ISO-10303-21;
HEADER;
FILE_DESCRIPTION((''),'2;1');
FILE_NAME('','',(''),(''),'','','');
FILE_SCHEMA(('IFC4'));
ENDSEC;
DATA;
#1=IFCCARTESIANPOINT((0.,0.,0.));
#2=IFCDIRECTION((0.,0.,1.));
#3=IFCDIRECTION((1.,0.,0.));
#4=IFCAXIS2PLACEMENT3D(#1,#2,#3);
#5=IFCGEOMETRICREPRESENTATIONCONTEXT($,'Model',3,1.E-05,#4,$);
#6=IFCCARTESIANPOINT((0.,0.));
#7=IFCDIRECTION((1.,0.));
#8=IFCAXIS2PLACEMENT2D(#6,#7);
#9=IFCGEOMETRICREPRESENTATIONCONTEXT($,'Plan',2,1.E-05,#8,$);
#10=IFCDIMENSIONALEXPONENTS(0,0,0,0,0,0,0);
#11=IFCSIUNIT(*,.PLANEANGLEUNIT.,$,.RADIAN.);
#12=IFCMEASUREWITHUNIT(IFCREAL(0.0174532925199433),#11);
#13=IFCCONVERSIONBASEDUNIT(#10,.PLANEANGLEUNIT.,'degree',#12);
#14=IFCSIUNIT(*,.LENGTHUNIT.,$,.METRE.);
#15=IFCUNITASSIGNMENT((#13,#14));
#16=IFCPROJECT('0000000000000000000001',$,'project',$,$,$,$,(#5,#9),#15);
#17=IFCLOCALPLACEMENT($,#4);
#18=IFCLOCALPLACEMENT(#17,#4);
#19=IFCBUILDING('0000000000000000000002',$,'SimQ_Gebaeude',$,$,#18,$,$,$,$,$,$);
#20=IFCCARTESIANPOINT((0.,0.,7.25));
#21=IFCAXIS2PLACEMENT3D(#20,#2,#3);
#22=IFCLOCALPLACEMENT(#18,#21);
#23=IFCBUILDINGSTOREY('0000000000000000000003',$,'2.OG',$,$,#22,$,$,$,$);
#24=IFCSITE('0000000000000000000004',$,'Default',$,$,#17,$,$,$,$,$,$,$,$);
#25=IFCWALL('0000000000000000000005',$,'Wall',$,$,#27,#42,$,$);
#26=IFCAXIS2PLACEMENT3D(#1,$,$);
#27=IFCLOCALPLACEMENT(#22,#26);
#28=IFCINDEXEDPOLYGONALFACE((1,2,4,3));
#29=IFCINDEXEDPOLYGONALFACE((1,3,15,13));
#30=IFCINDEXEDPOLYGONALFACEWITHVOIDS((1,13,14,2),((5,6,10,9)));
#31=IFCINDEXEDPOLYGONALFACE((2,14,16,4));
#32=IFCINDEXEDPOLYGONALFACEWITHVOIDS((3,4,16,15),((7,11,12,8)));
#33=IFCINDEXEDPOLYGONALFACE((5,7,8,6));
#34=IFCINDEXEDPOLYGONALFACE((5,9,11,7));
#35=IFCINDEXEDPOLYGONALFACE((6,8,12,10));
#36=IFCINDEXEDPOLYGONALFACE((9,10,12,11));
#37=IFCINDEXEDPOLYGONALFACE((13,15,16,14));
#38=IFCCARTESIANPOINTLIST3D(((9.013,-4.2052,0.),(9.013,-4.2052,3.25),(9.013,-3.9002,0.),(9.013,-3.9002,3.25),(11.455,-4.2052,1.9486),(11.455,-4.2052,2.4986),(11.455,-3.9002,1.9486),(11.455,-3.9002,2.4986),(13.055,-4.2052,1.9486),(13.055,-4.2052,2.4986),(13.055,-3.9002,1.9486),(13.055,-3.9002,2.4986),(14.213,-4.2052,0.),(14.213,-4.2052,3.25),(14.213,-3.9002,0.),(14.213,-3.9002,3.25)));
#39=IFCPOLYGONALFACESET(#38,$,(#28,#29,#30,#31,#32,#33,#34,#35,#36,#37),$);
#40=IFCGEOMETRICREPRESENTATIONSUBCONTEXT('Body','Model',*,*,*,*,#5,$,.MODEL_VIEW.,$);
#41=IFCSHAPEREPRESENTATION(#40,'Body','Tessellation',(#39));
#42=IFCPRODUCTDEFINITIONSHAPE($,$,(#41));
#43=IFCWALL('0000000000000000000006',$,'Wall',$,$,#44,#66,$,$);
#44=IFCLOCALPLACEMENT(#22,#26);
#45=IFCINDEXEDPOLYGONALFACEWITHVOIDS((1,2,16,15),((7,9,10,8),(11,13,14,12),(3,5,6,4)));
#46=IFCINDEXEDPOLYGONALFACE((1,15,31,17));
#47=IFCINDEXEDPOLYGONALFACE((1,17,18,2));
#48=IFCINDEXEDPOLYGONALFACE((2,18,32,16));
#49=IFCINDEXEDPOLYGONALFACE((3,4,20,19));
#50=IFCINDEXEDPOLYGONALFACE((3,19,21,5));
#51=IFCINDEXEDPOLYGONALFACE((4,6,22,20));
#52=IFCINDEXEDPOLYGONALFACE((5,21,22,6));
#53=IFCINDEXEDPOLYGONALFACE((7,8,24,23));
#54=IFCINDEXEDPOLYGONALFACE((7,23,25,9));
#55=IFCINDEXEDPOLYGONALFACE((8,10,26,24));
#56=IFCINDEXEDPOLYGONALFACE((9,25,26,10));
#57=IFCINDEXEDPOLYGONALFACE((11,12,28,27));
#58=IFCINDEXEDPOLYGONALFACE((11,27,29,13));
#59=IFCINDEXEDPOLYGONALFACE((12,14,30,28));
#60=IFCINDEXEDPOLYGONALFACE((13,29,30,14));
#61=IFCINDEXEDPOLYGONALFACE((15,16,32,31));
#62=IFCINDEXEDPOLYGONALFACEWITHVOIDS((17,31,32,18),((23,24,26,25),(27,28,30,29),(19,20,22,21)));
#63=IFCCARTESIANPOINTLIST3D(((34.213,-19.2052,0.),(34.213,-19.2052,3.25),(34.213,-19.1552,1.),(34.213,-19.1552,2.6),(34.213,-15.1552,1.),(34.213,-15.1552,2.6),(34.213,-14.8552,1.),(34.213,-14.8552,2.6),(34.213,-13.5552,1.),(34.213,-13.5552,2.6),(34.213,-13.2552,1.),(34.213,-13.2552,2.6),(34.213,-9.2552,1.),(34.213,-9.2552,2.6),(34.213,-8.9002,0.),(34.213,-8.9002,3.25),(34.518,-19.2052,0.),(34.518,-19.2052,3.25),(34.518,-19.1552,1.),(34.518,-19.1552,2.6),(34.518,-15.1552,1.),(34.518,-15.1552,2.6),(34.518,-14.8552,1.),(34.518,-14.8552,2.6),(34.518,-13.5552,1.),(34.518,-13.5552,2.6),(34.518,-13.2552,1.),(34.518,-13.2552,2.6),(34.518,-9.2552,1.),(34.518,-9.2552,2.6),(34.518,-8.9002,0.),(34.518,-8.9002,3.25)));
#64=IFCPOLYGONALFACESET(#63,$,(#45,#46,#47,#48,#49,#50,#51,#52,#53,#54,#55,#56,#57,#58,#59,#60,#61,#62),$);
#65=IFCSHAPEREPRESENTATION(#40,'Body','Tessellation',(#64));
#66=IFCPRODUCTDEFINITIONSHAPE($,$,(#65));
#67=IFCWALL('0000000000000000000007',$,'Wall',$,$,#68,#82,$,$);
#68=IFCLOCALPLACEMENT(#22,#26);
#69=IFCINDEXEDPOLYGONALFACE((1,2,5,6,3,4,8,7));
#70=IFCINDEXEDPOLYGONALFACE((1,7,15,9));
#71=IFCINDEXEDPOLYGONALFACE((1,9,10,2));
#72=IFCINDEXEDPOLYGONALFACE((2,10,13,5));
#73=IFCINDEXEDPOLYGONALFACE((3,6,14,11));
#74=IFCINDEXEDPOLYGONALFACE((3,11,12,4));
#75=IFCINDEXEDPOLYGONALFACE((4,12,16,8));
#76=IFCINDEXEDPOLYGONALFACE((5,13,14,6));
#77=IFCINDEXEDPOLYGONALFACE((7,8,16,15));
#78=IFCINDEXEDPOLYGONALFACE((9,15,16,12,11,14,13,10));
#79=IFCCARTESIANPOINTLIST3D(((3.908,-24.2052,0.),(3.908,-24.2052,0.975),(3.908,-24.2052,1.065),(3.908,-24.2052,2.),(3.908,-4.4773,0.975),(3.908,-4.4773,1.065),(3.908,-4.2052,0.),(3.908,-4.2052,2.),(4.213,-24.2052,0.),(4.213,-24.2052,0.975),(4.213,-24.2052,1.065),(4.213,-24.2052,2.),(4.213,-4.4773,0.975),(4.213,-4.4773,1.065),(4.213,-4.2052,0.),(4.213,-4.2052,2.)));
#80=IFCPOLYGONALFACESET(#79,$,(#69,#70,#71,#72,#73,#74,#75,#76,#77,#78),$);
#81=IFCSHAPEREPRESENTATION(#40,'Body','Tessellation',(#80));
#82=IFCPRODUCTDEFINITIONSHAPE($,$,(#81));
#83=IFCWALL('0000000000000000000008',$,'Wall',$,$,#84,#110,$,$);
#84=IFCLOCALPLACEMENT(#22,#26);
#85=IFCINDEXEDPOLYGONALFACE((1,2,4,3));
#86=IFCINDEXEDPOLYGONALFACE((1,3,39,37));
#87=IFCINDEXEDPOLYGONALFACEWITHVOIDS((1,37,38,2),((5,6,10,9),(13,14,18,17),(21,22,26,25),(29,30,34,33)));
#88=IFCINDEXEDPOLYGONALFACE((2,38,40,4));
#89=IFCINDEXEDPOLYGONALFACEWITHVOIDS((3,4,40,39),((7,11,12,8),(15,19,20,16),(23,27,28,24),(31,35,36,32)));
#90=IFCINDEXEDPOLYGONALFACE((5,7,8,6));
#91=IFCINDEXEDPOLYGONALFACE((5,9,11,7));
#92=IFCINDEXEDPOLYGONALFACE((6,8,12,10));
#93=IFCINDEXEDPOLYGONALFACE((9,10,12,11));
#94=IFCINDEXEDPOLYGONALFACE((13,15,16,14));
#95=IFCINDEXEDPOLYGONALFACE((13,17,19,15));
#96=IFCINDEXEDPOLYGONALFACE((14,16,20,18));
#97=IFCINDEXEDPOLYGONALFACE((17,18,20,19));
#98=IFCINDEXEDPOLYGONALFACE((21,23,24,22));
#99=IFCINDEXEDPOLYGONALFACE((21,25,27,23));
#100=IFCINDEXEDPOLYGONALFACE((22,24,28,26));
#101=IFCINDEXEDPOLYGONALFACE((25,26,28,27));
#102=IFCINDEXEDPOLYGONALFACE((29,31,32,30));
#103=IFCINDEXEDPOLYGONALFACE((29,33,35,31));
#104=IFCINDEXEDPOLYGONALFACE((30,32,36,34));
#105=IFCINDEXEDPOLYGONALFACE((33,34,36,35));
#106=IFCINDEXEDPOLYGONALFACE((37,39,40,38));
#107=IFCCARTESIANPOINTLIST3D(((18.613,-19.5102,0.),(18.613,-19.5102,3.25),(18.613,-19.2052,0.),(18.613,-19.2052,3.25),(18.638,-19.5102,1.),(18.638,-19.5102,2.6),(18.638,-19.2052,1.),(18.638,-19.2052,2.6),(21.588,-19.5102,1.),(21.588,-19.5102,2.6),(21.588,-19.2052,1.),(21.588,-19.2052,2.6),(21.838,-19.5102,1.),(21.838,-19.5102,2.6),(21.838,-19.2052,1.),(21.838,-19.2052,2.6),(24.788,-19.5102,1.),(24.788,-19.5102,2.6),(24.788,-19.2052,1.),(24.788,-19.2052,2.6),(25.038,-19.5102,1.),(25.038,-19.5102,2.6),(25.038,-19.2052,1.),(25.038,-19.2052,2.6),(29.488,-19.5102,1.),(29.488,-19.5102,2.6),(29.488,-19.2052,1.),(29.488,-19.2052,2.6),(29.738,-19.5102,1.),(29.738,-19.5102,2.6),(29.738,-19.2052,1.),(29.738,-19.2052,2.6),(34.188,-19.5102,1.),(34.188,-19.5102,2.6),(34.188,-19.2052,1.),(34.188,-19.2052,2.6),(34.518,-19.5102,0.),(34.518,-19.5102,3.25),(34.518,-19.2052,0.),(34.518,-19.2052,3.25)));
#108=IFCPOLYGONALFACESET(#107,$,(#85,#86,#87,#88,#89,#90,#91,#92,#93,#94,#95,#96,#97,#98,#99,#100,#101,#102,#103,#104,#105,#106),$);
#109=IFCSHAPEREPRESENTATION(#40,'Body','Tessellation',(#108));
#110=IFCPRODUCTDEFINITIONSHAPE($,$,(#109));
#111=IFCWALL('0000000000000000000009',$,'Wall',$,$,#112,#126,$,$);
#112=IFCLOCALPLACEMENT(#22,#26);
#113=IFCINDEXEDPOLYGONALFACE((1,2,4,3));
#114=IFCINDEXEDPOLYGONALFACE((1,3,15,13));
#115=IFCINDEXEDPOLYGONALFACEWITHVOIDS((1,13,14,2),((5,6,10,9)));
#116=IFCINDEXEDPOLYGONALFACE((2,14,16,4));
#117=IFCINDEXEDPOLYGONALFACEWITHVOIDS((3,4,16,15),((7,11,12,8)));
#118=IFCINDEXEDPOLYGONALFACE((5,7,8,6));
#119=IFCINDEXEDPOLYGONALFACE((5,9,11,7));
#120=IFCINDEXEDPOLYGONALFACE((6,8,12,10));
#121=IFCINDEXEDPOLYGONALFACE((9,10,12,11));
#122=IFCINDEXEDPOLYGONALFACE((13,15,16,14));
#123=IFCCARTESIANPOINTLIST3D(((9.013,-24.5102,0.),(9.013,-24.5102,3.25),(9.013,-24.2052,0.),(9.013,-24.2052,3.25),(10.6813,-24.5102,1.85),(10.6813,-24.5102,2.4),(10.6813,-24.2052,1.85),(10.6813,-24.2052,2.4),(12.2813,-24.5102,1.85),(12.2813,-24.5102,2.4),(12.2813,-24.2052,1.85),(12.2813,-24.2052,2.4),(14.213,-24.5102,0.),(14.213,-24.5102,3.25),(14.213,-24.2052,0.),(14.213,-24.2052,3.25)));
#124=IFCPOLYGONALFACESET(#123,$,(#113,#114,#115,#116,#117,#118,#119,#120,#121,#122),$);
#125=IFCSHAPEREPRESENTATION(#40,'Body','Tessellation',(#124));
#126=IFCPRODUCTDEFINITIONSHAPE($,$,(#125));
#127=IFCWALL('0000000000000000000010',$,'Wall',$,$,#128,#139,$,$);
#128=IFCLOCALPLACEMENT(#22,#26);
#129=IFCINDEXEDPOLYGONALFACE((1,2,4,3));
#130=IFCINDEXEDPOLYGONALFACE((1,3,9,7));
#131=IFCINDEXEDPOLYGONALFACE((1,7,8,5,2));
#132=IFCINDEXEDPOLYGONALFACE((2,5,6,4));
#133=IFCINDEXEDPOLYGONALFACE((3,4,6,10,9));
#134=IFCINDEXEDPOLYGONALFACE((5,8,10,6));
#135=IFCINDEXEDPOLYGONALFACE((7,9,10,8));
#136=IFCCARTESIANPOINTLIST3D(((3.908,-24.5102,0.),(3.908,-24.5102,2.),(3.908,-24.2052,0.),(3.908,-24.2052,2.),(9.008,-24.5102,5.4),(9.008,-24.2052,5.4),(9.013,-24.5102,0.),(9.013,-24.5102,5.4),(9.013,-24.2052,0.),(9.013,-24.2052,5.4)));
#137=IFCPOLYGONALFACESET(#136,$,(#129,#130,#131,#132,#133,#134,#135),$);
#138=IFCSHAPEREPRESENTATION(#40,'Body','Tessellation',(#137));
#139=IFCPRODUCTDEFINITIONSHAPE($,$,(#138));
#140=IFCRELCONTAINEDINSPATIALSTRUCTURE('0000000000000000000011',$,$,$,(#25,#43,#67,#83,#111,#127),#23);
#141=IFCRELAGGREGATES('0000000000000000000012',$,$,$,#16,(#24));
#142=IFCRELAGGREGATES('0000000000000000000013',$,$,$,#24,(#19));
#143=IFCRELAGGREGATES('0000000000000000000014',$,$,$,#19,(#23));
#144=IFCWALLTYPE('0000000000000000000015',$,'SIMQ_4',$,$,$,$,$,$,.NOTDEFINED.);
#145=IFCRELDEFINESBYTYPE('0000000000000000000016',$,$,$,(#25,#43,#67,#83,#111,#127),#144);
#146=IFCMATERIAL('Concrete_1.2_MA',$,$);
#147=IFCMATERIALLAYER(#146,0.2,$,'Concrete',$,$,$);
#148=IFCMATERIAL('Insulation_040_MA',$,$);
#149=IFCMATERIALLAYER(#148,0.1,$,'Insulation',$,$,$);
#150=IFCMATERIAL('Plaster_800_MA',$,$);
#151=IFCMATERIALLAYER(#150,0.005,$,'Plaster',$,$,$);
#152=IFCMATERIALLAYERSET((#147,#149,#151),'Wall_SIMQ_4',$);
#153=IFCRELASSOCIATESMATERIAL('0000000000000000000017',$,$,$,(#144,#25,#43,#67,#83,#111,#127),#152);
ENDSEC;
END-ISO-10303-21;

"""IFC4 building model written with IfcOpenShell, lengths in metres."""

from ifc_helpers import new_model, entity, si_unit, converted_unit, frame, origin_with_axes, origin_2d_with_axis, place, context, subcontext, project, spatial, line, indexed_curve, outline, extrude, clip, halfspace, source, transform, mapped, material, layer, layer_set, layer_usage, type_object, element, save


model = new_model("IFC4")

# Units and contexts
model_context = context("Model", 3, precision=1e-05, world=origin_with_axes())
plan_context = context("Plan", 2, precision=1e-05, world=origin_2d_with_axis())
body_context = subcontext(model_context, "Body", "Model", "MODEL_VIEW")
ifc_project = project(units=[converted_unit("PLANEANGLEUNIT", "degree", entity("IfcReal", 0.0174532925199433), si_unit("PLANEANGLEUNIT", "RADIAN"), dimensions=[0, 0, 0, 0, 0, 0, 0]), si_unit("LENGTHUNIT", "METRE")], contexts=[model_context, plan_context])

# Site, building, storey
site_placement = place(None, origin_with_axes())
site = spatial("IfcSite", under=ifc_project, at=site_placement, Name="Default")
building_placement = place(site_placement, origin_with_axes())
building = spatial("IfcBuilding", under=site, at=building_placement, Name="SimQ_Gebaeude")
storey_placement = place(building_placement, frame((0.0, 0.0, 7.25), z_axis=(0.0, 0.0, 1.0), x_axis=(1.0, 0.0, 0.0)))
storey = spatial("IfcBuildingStorey", under=building, at=storey_placement, Name="2.OG")

# Shared definitions
ifc_material_1 = material(Name="Insulation_040_MA")
ifc_material_2 = material(Name="Concrete_1.2_MA")

# Shared definitions
ifc_layer_1 = layer(ifc_material_2, 0.2, Name="Concrete")
ifc_layer_2 = layer(ifc_material_1, 0.1, Name="Insulation")
ifc_material_3 = material(Name="Plaster_800_MA")
ifc_layer_3 = layer(ifc_material_3, 0.005, Name="Plaster")
ifc_layer_set_1 = layer_set([ifc_layer_1, ifc_layer_2, ifc_layer_3], Name="Wall_SIMQ_4")
wall_type_1 = type_object("IfcWallType", Name="SIMQ_4", PredefinedType="NOTDEFINED", material=ifc_layer_set_1)
shared_shape_1 = source(origin_with_axes(), body_context, "Body", "SweptSolid", [
    extrude(outline(indexed_curve([(0.0, 0.0), (2.95, 0.0), (2.95, 1.6), (0.0, 1.6)], segments=[line(1, 2, 3, 4, 1)])), frame((0.0, -0.6, 0.0), z_axis=(0.0, -1.0, 0.0), x_axis=(1.0, 0.0, 0.0)), (0.0, 0.0, -1.0), 1.2),
])
shared_shape_2 = source(origin_with_axes(), body_context, "Body", "SweptSolid", [
    extrude(outline(indexed_curve([(0.0, 0.0), (4.45, 0.0), (4.45, 1.6), (0.0, 1.6)], segments=[line(1, 2, 3, 4, 1)])), frame((0.0, -0.6, 0.0), z_axis=(0.0, -1.0, 0.0), x_axis=(1.0, 0.0, 0.0)), (0.0, 0.0, -1.0), 1.2),
])

# Wall, opening
ifc_layer_usage_1 = layer_usage(ifc_layer_set_1, "AXIS2", "POSITIVE", 0.0)
wall_1_placement = place(storey_placement, frame((14.213, -3.9002, 0.0), z_axis=(0.0, 0.0, 1.0), x_axis=(-1.0, 0.0, 0.0)))
wall_1 = element("IfcWall", 1, at=wall_1_placement, inside=storey, type_object=wall_type_1, material=ifc_layer_usage_1, Name="Wall", context=body_context, shape_type="SweptSolid", body=[
    extrude(outline(indexed_curve([(0.0, 0.0), (0.0, 0.305), (5.2, 0.305), (5.2, 0.0), (0.0, 0.0)], self_intersect=False)), origin_with_axes(), (0.0, 0.0, 1.0), 3.25),
])
shared_shape_3 = source(origin_with_axes(), body_context, "Body", "SweptSolid", [
    extrude(outline(indexed_curve([(0.0, 0.0), (1.6, 0.0), (1.6, 0.55), (0.0, 0.55)], segments=[line(1, 2, 3, 4, 1)])), frame((0.0, -0.6, 0.0), z_axis=(0.0, -1.0, 0.0), x_axis=(1.0, 0.0, 0.0)), (0.0, 0.0, -1.0), 1.2),
])
opening_1_placement = place(wall_1_placement, frame((1.158, 0.0, 1.9486), z_axis=(0.0, 0.0, 1.0), x_axis=(1.0, 0.0, 0.0)))
element("IfcOpeningElement", 2, at=opening_1_placement, cuts=wall_1, PredefinedType="OPENING", context=body_context, shape_type="MappedRepresentation", body=[
    mapped(shared_shape_3, transform((0.0, 0.0, 0.0), x_axis=(1.0, 0.0, 0.0), y_axis=(0.0, 1.0, 0.0), z_axis=(0.0, 0.0, 1.0), scale=1.0)),
])

# Wall, openings
ifc_layer_usage_2 = layer_usage(ifc_layer_set_1, "AXIS2", "POSITIVE", 0.0)
wall_2_placement = place(storey_placement, frame((34.518, -19.2052, 0.0), z_axis=(0.0, 0.0, 1.0), x_axis=(0.0, 1.0, 0.0)))
wall_2 = element("IfcWall", 3, at=wall_2_placement, inside=storey, type_object=wall_type_1, material=ifc_layer_usage_2, Name="Wall", context=body_context, shape_type="SweptSolid", body=[
    extrude(outline(indexed_curve([(0.0, 0.0), (0.0, 0.305), (10.305, 0.305), (10.305, 0.0), (0.0, 0.0)], self_intersect=False)), origin_with_axes(), (0.0, 0.0, 1.0), 3.25),
])
shared_shape_4 = source(origin_with_axes(), body_context, "Body", "SweptSolid", [
    extrude(outline(indexed_curve([(0.0, 0.0), (4.0, 0.0), (4.0, 1.6), (0.0, 1.6)], segments=[line(1, 2, 3, 4, 1)])), frame((0.0, -0.6, 0.0), z_axis=(0.0, -1.0, 0.0), x_axis=(1.0, 0.0, 0.0)), (0.0, 0.0, -1.0), 1.2),
])
opening_2_placement = place(wall_2_placement, frame((0.05, 0.0, 1.0), z_axis=(0.0, 0.0, 1.0), x_axis=(1.0, 0.0, 0.0)))
element("IfcOpeningElement", 4, at=opening_2_placement, cuts=wall_2, PredefinedType="OPENING", context=body_context, shape_type="MappedRepresentation", body=[
    mapped(shared_shape_4, transform((0.0, 0.0, 0.0), x_axis=(1.0, 0.0, 0.0), y_axis=(0.0, 1.0, 0.0), z_axis=(0.0, 0.0, 1.0), scale=1.0)),
])
opening_3_placement = place(wall_2_placement, frame((5.95, 0.0, 1.0), z_axis=(0.0, 0.0, 1.0), x_axis=(1.0, 0.0, 0.0)))
element("IfcOpeningElement", 5, at=opening_3_placement, cuts=wall_2, PredefinedType="OPENING", context=body_context, shape_type="MappedRepresentation", body=[
    mapped(shared_shape_4, transform((0.0, 0.0, 0.0), x_axis=(1.0, 0.0, 0.0), y_axis=(0.0, 1.0, 0.0), z_axis=(0.0, 0.0, 1.0), scale=1.0)),
])
shared_shape_5 = source(origin_with_axes(), body_context, "Body", "SweptSolid", [
    extrude(outline(indexed_curve([(0.0, 0.0), (1.3, 0.0), (1.3, 1.6), (0.0, 1.6)], segments=[line(1, 2, 3, 4, 1)])), frame((0.0, -0.6, 0.0), z_axis=(0.0, -1.0, 0.0), x_axis=(1.0, 0.0, 0.0)), (0.0, 0.0, -1.0), 1.2),
])
opening_4_placement = place(wall_2_placement, frame((4.35, 0.0, 1.0), z_axis=(0.0, 0.0, 1.0), x_axis=(1.0, 0.0, 0.0)))
element("IfcOpeningElement", 6, at=opening_4_placement, cuts=wall_2, PredefinedType="OPENING", context=body_context, shape_type="MappedRepresentation", body=[
    mapped(shared_shape_5, transform((0.0, 0.0, 0.0), x_axis=(1.0, 0.0, 0.0), y_axis=(0.0, 1.0, 0.0), z_axis=(0.0, 0.0, 1.0), scale=1.0)),
])

# Wall, opening
ifc_layer_usage_3 = layer_usage(ifc_layer_set_1, "AXIS2", "POSITIVE", 0.0)
wall_3_placement = place(storey_placement, frame((3.908, -4.2052, 0.0), z_axis=(0.0, 0.0, 1.0), x_axis=(-0.000001, -1.0, 0.0)))
wall_3 = element("IfcWall", 7, at=wall_3_placement, inside=storey, type_object=wall_type_1, material=ifc_layer_usage_3, Name="Wall", context=body_context, shape_type="SweptSolid", body=[
    extrude(outline(indexed_curve([(0.0, 0.0), (0.0, 0.305), (20.0, 0.305), (20.0, 0.0), (0.0, 0.0)], self_intersect=False)), origin_with_axes(), (0.0, 0.0, 1.0), 2.0),
])
shared_shape_6 = source(origin_with_axes(), body_context, "Body", "SweptSolid", [
    extrude(outline(indexed_curve([(0.0, 0.0), (20.0, 0.0), (20.0, 0.09), (0.0, 0.09)], segments=[line(1, 2, 3, 4, 1)])), frame((0.0, -0.6, -0.025), z_axis=(0.0, -1.0, 0.0), x_axis=(1.0, 0.0, 0.0)), (0.0, 0.0, -1.0), 1.2),
])
opening_5_placement = place(wall_3_placement, frame((0.2722, 0.0, 1.0), z_axis=(0.0, 0.0, 1.0), x_axis=(1.0, 0.0, 0.0)))
element("IfcOpeningElement", 8, at=opening_5_placement, cuts=wall_3, PredefinedType="OPENING", context=body_context, shape_type="MappedRepresentation", body=[
    mapped(shared_shape_6, transform((0.0, 0.0, 0.0), x_axis=(1.0, 0.0, 0.0), y_axis=(0.0, 1.0, 0.0), z_axis=(0.0, 0.0, 1.0), scale=1.0)),
])

# Wall, openings
ifc_layer_usage_4 = layer_usage(ifc_layer_set_1, "AXIS2", "POSITIVE", 0.0)
wall_4_placement = place(storey_placement, frame((18.613, -19.5102, 0.0), z_axis=(0.0, 0.0, 1.0), x_axis=(1.0, 0.0, 0.0)))
wall_4 = element("IfcWall", 9, at=wall_4_placement, inside=storey, type_object=wall_type_1, material=ifc_layer_usage_4, Name="Wall", context=body_context, shape_type="SweptSolid", body=[
    extrude(outline(indexed_curve([(0.0, 0.0), (0.0, 0.305), (15.905, 0.305), (15.905, 0.0), (0.0, 0.0)], self_intersect=False)), origin_with_axes(), (0.0, 0.0, 1.0), 3.25),
])
opening_6_placement = place(wall_4_placement, frame((0.025, 0.0, 1.0), z_axis=(0.0, 0.0, 1.0), x_axis=(1.0, 0.0, 0.0)))
element("IfcOpeningElement", 10, at=opening_6_placement, cuts=wall_4, PredefinedType="OPENING", context=body_context, shape_type="MappedRepresentation", body=[
    mapped(shared_shape_1, transform((0.0, 0.0, 0.0), x_axis=(1.0, 0.0, 0.0), y_axis=(0.0, 1.0, 0.0), z_axis=(0.0, 0.0, 1.0), scale=1.0)),
])
opening_7_placement = place(wall_4_placement, frame((3.225, 0.0, 1.0), z_axis=(0.0, 0.0, 1.0), x_axis=(1.0, 0.0, 0.0)))
element("IfcOpeningElement", 11, at=opening_7_placement, cuts=wall_4, PredefinedType="OPENING", context=body_context, shape_type="MappedRepresentation", body=[
    mapped(shared_shape_1, transform((0.0, 0.0, 0.0), x_axis=(1.0, 0.0, 0.0), y_axis=(0.0, 1.0, 0.0), z_axis=(0.0, 0.0, 1.0), scale=1.0)),
])
opening_8_placement = place(wall_4_placement, frame((6.425, 0.0, 1.0), z_axis=(0.0, 0.0, 1.0), x_axis=(1.0, 0.0, 0.0)))
element("IfcOpeningElement", 12, at=opening_8_placement, cuts=wall_4, PredefinedType="OPENING", context=body_context, shape_type="MappedRepresentation", body=[
    mapped(shared_shape_2, transform((0.0, 0.0, 0.0), x_axis=(1.0, 0.0, 0.0), y_axis=(0.0, 1.0, 0.0), z_axis=(0.0, 0.0, 1.0), scale=1.0)),
])
opening_9_placement = place(wall_4_placement, frame((11.125, 0.0, 1.0), z_axis=(0.0, 0.0, 1.0), x_axis=(1.0, 0.0, 0.0)))
element("IfcOpeningElement", 13, at=opening_9_placement, cuts=wall_4, PredefinedType="OPENING", context=body_context, shape_type="MappedRepresentation", body=[
    mapped(shared_shape_2, transform((0.0, 0.0, 0.0), x_axis=(1.0, 0.0, 0.0), y_axis=(0.0, 1.0, 0.0), z_axis=(0.0, 0.0, 1.0), scale=1.0)),
])

# Wall, opening
ifc_layer_usage_5 = layer_usage(ifc_layer_set_1, "AXIS2", "POSITIVE", 0.0)
wall_5_placement = place(storey_placement, frame((9.013, -24.5102, 0.0), z_axis=(0.0, 0.0, 1.0), x_axis=(1.0, -0.000001, 0.0)))
wall_5 = element("IfcWall", 14, at=wall_5_placement, inside=storey, type_object=wall_type_1, material=ifc_layer_usage_5, Name="Wall", context=body_context, shape_type="SweptSolid", body=[
    extrude(outline(indexed_curve([(0.0, 0.0), (0.0, 0.305), (5.2, 0.305), (5.2, 0.0), (0.0, 0.0)], self_intersect=False)), origin_with_axes(), (0.0, 0.0, 1.0), 3.25),
])
opening_10_placement = place(wall_5_placement, frame((1.6682, 0.0, 1.85), z_axis=(0.0, 0.0, 1.0), x_axis=(1.0, 0.0, 0.0)))
element("IfcOpeningElement", 15, at=opening_10_placement, cuts=wall_5, PredefinedType="OPENING", context=body_context, shape_type="MappedRepresentation", body=[
    mapped(shared_shape_3, transform((0.0, 0.0, 0.0), x_axis=(1.0, 0.0, 0.0), y_axis=(0.0, 1.0, 0.0), z_axis=(0.0, 0.0, 1.0), scale=1.0)),
])

# Wall
ifc_layer_usage_6 = layer_usage(ifc_layer_set_1, "AXIS2", "POSITIVE", 0.0)
wall_6_placement = place(storey_placement, frame((3.908, -24.5102, 0.0), z_axis=(0.0, 0.0, 1.0), x_axis=(1.0, 0.0, 0.0)))
element("IfcWall", 16, at=wall_6_placement, inside=storey, type_object=wall_type_1, material=ifc_layer_usage_6, Name="Wall", context=body_context, shape_type="Clipping", body=[
    clip(extrude(outline(indexed_curve([(0.0, 0.0), (0.0, 0.305), (5.105, 0.305), (5.105, 0.0), (0.0, 0.0)], self_intersect=False)), origin_with_axes(), (0.0, 0.0, 1.0), 5.4), halfspace(frame((0.416, 0.5, 2.2773), z_axis=(-0.554699, 0.0, 0.832051), x_axis=(0.832051, 0.0, 0.554699)), False)),
])

save(model, "model.ifc")
